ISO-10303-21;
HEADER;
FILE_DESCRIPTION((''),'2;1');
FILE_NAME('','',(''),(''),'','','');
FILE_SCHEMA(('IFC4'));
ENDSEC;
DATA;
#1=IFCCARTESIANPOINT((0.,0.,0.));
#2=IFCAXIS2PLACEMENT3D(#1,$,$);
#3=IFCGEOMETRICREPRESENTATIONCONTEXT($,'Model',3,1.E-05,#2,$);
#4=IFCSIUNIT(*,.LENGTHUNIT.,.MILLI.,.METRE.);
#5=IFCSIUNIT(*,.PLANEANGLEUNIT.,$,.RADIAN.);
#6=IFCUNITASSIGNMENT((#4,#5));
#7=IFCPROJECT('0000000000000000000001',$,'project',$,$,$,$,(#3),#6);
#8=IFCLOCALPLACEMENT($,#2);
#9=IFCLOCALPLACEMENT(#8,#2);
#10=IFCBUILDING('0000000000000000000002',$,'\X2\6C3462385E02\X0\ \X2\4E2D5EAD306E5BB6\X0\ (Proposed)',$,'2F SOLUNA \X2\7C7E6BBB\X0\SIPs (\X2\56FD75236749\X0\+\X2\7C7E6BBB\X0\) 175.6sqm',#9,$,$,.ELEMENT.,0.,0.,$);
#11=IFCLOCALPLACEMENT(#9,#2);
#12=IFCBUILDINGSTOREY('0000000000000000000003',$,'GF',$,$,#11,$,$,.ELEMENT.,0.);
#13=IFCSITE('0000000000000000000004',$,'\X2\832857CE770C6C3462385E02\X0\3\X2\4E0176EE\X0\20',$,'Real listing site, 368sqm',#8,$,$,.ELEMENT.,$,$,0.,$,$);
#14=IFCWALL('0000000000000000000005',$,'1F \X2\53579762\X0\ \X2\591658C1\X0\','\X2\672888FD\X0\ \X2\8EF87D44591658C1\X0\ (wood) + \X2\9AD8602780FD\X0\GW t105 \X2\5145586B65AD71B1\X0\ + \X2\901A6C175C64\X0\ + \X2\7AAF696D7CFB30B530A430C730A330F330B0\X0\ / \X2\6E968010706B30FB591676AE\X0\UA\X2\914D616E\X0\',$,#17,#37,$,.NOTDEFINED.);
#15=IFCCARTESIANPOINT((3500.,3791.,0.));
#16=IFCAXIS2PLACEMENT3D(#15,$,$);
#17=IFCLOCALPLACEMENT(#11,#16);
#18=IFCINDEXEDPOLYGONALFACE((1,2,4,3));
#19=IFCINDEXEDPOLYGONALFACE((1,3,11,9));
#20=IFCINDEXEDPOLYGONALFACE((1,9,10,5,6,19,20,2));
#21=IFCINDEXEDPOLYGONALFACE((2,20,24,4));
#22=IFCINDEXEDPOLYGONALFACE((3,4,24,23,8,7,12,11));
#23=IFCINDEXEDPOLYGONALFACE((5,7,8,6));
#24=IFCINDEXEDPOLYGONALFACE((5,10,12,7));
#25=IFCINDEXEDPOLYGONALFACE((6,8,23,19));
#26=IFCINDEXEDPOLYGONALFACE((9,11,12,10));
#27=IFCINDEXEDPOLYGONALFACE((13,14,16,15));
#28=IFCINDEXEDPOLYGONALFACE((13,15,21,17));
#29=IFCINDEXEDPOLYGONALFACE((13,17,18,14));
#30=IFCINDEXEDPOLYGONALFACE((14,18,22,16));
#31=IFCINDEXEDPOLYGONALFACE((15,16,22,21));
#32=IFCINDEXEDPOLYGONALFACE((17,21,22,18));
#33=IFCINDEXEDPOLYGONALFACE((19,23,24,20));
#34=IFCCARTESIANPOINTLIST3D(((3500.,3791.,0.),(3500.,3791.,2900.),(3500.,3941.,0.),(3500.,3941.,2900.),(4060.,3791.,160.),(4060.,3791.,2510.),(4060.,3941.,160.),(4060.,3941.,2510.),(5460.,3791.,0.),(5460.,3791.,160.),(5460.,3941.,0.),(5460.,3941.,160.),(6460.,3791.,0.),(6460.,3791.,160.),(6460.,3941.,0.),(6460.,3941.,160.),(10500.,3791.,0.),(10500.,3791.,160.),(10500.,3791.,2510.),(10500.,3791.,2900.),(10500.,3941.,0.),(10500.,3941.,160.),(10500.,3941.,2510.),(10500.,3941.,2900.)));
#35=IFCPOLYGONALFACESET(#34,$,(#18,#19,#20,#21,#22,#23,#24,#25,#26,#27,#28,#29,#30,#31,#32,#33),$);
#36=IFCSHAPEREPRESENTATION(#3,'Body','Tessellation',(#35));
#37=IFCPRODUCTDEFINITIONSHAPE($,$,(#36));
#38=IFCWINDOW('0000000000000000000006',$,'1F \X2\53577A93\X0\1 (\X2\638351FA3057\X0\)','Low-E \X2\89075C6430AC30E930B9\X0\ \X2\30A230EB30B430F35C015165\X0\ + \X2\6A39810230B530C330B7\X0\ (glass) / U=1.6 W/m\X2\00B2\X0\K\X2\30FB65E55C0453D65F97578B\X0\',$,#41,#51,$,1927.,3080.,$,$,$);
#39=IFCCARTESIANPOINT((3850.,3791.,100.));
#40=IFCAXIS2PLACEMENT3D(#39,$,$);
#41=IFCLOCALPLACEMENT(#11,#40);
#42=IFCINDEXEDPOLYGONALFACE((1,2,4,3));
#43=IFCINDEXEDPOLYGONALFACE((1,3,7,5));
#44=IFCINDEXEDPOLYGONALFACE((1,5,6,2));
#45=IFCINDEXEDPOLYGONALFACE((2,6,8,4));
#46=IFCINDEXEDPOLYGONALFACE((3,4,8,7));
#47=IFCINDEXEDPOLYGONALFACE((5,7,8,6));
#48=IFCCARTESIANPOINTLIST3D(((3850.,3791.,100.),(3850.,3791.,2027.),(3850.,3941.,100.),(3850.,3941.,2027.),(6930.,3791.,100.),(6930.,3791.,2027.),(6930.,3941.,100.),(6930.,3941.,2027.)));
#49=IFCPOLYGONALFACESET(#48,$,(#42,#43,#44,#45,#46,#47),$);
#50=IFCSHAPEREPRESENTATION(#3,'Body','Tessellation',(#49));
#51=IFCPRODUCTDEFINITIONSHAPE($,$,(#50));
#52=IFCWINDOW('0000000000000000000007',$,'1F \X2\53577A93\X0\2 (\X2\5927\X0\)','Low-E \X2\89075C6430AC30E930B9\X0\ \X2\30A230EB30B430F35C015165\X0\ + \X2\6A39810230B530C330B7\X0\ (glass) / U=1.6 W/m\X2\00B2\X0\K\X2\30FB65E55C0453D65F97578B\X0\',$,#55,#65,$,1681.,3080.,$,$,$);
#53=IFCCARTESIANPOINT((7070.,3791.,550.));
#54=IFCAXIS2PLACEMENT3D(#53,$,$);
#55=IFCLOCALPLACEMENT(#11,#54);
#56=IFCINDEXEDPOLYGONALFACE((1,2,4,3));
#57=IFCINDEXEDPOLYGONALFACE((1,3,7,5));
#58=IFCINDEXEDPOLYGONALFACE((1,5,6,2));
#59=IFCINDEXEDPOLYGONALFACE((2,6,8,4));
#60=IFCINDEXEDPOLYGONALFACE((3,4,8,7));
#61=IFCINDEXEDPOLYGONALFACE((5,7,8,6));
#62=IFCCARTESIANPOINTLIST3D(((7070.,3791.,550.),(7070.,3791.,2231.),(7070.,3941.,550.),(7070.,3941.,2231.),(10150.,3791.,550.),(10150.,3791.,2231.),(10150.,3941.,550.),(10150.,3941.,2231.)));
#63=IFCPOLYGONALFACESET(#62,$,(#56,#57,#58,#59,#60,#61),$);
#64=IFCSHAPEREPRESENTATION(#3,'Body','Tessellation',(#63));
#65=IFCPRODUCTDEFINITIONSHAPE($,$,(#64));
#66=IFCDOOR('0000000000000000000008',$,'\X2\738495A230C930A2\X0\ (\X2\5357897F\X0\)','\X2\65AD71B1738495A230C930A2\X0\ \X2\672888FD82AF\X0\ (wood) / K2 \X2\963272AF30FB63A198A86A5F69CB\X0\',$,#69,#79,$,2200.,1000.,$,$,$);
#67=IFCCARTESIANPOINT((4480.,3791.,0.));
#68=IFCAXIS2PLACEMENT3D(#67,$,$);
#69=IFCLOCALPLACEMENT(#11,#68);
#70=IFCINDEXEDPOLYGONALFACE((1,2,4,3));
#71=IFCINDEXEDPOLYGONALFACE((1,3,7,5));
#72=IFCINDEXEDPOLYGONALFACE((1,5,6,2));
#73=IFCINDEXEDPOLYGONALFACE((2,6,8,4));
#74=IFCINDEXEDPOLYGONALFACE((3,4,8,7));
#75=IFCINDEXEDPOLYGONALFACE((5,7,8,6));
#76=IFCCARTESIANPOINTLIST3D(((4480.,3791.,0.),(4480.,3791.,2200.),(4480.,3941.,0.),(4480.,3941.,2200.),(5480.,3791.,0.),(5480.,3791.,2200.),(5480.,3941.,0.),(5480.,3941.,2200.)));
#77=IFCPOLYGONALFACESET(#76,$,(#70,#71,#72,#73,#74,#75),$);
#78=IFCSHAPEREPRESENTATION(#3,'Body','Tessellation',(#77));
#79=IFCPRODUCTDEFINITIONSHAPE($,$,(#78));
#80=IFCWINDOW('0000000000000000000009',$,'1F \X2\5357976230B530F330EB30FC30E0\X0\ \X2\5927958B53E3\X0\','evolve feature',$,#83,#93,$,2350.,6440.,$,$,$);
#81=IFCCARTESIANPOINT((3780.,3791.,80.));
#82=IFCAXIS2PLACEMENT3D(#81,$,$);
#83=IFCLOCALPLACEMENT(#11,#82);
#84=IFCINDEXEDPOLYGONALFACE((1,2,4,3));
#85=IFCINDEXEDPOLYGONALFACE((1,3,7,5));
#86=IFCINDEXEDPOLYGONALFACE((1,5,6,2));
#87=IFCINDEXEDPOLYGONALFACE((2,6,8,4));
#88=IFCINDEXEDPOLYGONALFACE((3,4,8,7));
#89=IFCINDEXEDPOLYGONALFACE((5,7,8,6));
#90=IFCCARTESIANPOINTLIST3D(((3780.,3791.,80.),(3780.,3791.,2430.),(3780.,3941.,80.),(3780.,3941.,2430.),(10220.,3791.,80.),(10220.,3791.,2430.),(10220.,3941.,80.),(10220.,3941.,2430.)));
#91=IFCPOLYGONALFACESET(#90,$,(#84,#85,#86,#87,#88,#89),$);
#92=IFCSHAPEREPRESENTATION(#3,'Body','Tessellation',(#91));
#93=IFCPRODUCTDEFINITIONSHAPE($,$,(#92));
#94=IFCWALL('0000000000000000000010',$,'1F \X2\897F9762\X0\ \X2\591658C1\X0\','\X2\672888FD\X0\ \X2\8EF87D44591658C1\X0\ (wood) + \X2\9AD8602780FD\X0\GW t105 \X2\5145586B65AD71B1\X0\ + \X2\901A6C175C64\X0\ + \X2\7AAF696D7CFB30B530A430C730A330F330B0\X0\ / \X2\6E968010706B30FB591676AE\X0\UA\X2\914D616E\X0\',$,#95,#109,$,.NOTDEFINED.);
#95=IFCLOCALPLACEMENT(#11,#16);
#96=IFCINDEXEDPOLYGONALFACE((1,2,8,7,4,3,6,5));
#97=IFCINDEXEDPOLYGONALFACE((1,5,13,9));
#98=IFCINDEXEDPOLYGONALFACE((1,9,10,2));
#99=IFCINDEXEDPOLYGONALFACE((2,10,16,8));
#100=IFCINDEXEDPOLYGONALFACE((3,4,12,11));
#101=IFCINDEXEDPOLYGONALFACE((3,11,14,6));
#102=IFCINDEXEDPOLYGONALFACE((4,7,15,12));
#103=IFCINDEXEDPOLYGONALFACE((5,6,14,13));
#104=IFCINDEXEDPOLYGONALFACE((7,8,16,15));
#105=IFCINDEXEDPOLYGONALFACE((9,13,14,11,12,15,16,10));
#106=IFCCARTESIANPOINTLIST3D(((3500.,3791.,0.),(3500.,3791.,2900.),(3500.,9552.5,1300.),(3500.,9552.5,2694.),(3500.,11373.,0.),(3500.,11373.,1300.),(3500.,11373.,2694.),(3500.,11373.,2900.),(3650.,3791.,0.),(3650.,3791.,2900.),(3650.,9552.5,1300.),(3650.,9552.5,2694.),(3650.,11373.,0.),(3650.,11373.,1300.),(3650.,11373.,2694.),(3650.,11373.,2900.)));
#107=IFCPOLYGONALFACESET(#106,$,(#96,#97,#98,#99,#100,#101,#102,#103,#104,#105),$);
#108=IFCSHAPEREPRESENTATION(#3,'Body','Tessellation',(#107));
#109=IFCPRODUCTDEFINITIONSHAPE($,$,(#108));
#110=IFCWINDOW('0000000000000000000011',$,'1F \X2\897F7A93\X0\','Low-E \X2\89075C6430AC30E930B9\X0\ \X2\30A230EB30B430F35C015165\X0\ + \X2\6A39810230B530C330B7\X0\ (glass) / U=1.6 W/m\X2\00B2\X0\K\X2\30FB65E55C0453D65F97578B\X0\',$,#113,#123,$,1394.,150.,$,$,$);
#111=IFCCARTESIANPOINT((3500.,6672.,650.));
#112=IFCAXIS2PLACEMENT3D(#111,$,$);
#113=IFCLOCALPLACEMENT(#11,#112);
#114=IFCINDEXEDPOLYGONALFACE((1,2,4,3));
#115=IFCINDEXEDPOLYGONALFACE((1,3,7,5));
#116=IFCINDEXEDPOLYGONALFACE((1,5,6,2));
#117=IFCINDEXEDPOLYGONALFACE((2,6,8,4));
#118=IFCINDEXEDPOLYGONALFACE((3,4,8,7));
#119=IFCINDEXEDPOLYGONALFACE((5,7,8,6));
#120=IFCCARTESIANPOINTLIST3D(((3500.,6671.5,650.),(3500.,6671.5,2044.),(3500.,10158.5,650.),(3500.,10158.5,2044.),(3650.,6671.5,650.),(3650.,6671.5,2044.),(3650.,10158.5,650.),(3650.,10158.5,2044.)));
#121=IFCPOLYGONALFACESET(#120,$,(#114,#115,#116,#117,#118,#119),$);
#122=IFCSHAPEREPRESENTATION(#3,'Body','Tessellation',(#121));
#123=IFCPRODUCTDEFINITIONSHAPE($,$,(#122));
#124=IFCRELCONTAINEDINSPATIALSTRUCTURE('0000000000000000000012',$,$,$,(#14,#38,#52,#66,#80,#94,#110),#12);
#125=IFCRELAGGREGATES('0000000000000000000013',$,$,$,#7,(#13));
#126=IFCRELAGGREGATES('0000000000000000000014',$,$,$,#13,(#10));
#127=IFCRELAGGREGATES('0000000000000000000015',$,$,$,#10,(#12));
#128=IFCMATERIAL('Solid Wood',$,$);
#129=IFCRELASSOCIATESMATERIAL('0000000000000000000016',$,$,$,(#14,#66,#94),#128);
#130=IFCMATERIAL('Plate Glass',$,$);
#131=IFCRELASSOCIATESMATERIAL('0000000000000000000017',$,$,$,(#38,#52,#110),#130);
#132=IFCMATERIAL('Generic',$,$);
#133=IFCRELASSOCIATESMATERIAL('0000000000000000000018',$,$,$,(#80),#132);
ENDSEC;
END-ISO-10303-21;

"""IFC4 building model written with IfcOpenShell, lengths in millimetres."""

from ifc_helpers import new_model, si_unit, frame, frame_2d, origin, place, context, project, spatial, rectangle, extrude, material, element, fill, save


model = new_model("IFC4")

# Units and contexts
model_context = context("Model", 3, precision=1e-05, world=origin())
ifc_project = project(units=[si_unit("LENGTHUNIT", "METRE", prefix="MILLI"), si_unit("PLANEANGLEUNIT", "RADIAN")], contexts=[model_context])

# Site, building, storey
site_placement = place(None, origin())
site = spatial("IfcSite", under=ifc_project, at=site_placement, Name="茨城県水戸市3丁目20", ObjectType="Real listing site, 368sqm", CompositionType="ELEMENT", RefElevation=0.0)
building_placement = place(site_placement, origin())
building = spatial("IfcBuilding", under=site, at=building_placement, Name="水戸市 中庭の家 (Proposed)", ObjectType="2F SOLUNA 籾殻SIPs (国産杉+籾殻) 175.6sqm", CompositionType="ELEMENT", ElevationOfRefHeight=0.0, ElevationOfTerrain=0.0)
storey_placement = place(building_placement, origin())
storey = spatial("IfcBuildingStorey", under=building, at=storey_placement, Name="GF", CompositionType="ELEMENT", Elevation=0.0)

# Shared definitions
ifc_material_1 = material(Name="Solid Wood")
ifc_material_2 = material(Name="Generic")

# Wall, openings, windows, door
wall_1_placement = place(storey_placement, frame((3500.0, 3791.0, 0.0)))
wall_1 = element("IfcWall", 1, at=wall_1_placement, inside=storey, material=ifc_material_1, Name="1F 南面 外壁", Description="木製 軸組外壁 (wood) + 高性能GW t105 充填断熱 + 通気層 + 窯業系サイディング / 準耐火・外皮UA配慮", PredefinedType="NOTDEFINED", context=model_context, shape_type="SweptSolid", body=[
    extrude(rectangle(XDim=7000.0, YDim=150.0, at=frame_2d((3500.0, 75.0))), frame((3500.0, 3791.0, 0.0)), (0.0, 0.0, 1.0), 2900.0),
])
opening_1_placement = place(storey_placement, frame((3850.0, 3791.0, 100.0)))
opening_1 = element("IfcOpeningElement", 2, at=opening_1_placement, cuts=wall_1, PredefinedType="NOTDEFINED", context=model_context, shape_type="SweptSolid", body=[
    extrude(rectangle(XDim=3080.0, YDim=150.0, at=frame_2d((1540.0, 75.0))), frame((3850.0, 3791.0, 100.0)), (0.0, 0.0, 1.0), 1927.0),
])
opening_2_placement = place(storey_placement, frame((7070.0, 3791.0, 550.0)))
opening_2 = element("IfcOpeningElement", 3, at=opening_2_placement, cuts=wall_1, PredefinedType="NOTDEFINED", context=model_context, shape_type="SweptSolid", body=[
    extrude(rectangle(XDim=3080.0, YDim=150.0, at=frame_2d((1540.0, 75.0))), frame((7070.0, 3791.0, 550.0)), (0.0, 0.0, 1.0), 1681.0),
])
opening_3_placement = place(storey_placement, frame((4480.0, 3791.0, 0.0)))
opening_3 = element("IfcOpeningElement", 4, at=opening_3_placement, cuts=wall_1, PredefinedType="NOTDEFINED", context=model_context, shape_type="SweptSolid", body=[
    extrude(rectangle(XDim=1000.0, YDim=150.0, at=frame_2d((500.0, 75.0))), frame((4480.0, 3791.0, 0.0)), (0.0, 0.0, 1.0), 2200.0),
])
opening_4_placement = place(storey_placement, frame((3780.0, 3791.0, 80.0)))
opening_4 = element("IfcOpeningElement", 5, at=opening_4_placement, cuts=wall_1, PredefinedType="NOTDEFINED", context=model_context, shape_type="SweptSolid", body=[
    extrude(rectangle(XDim=6440.0, YDim=150.0, at=frame_2d((3220.0, 75.0))), frame((3780.0, 3791.0, 80.0)), (0.0, 0.0, 1.0), 2350.0),
])
ifc_material_3 = material(Name="Plate Glass")
window_1_placement = place(storey_placement, frame((3850.0, 3791.0, 100.0)))
window_1 = element("IfcWindow", 6, at=window_1_placement, inside=storey, material=ifc_material_3, Name="1F 南窓1 (掃出し)", Description="Low-E 複層ガラス アルゴン封入 + 樹脂サッシ (glass) / U=1.6 W/m²K・日射取得型", OverallHeight=1927.0, OverallWidth=3080.0, context=model_context, shape_type="SweptSolid", body=[
    extrude(rectangle(XDim=3080.0, YDim=150.0, at=frame_2d((1540.0, 75.0))), frame((3850.0, 3791.0, 100.0)), (0.0, 0.0, 1.0), 1927.0),
])
fill(opening_1, window_1)
window_2_placement = place(storey_placement, frame((7070.0, 3791.0, 550.0)))
window_2 = element("IfcWindow", 7, at=window_2_placement, inside=storey, material=ifc_material_3, Name="1F 南窓2 (大)", Description="Low-E 複層ガラス アルゴン封入 + 樹脂サッシ (glass) / U=1.6 W/m²K・日射取得型", OverallHeight=1681.0, OverallWidth=3080.0, context=model_context, shape_type="SweptSolid", body=[
    extrude(rectangle(XDim=3080.0, YDim=150.0, at=frame_2d((1540.0, 75.0))), frame((7070.0, 3791.0, 550.0)), (0.0, 0.0, 1.0), 1681.0),
])
fill(opening_2, window_2)
door_placement = place(storey_placement, frame((4480.0, 3791.0, 0.0)))
door = element("IfcDoor", 8, at=door_placement, inside=storey, material=ifc_material_1, Name="玄関ドア (南西)", Description="断熱玄関ドア 木製芯 (wood) / K2 防犯・採風機構", OverallHeight=2200.0, OverallWidth=1000.0, context=model_context, shape_type="SweptSolid", body=[
    extrude(rectangle(XDim=1000.0, YDim=150.0, at=frame_2d((500.0, 75.0))), frame((4480.0, 3791.0, 0.0)), (0.0, 0.0, 1.0), 2200.0),
])
fill(opening_3, door)
window_3_placement = place(storey_placement, frame((3780.0, 3791.0, 80.0)))
window_3 = element("IfcWindow", 9, at=window_3_placement, inside=storey, material=ifc_material_2, Name="1F 南面サンルーム 大開口", Description="evolve feature", OverallHeight=2350.0, OverallWidth=6440.0, context=model_context, shape_type="SweptSolid", body=[
    extrude(rectangle(XDim=6440.0, YDim=150.0, at=frame_2d((3220.0, 75.0))), frame((3780.0, 3791.0, 80.0)), (0.0, 0.0, 1.0), 2350.0),
])
fill(opening_4, window_3)

# Wall, opening, window
wall_2_placement = place(storey_placement, frame((3500.0, 3791.0, 0.0)))
wall_2 = element("IfcWall", 10, at=wall_2_placement, inside=storey, material=ifc_material_1, Name="1F 西面 外壁", Description="木製 軸組外壁 (wood) + 高性能GW t105 充填断熱 + 通気層 + 窯業系サイディング / 準耐火・外皮UA配慮", PredefinedType="NOTDEFINED", context=model_context, shape_type="SweptSolid", body=[
    extrude(rectangle(XDim=150.0, YDim=7582.0, at=frame_2d((75.0, 3791.0))), frame((3500.0, 3791.0, 0.0)), (0.0, 0.0, 1.0), 2900.0),
])
opening_5_placement = place(storey_placement, frame((3500.0, 6672.0, 650.0)))
opening_5 = element("IfcOpeningElement", 11, at=opening_5_placement, cuts=wall_2, PredefinedType="NOTDEFINED", context=model_context, shape_type="SweptSolid", body=[
    extrude(rectangle(XDim=150.0, YDim=3487.0, at=frame_2d((75.0, 1743.0))), frame((3500.0, 6672.0, 650.0)), (0.0, 0.0, 1.0), 1394.0),
])
window_4_placement = place(storey_placement, frame((3500.0, 6672.0, 650.0)))
window_4 = element("IfcWindow", 12, at=window_4_placement, inside=storey, material=ifc_material_3, Name="1F 西窓", Description="Low-E 複層ガラス アルゴン封入 + 樹脂サッシ (glass) / U=1.6 W/m²K・日射取得型", OverallHeight=1394.0, OverallWidth=150.0, context=model_context, shape_type="SweptSolid", body=[
    extrude(rectangle(XDim=150.0, YDim=3487.0, at=frame_2d((75.0, 1743.0))), frame((3500.0, 6672.0, 650.0)), (0.0, 0.0, 1.0), 1394.0),
])
fill(opening_5, window_4)

save(model, "model.ifc")
